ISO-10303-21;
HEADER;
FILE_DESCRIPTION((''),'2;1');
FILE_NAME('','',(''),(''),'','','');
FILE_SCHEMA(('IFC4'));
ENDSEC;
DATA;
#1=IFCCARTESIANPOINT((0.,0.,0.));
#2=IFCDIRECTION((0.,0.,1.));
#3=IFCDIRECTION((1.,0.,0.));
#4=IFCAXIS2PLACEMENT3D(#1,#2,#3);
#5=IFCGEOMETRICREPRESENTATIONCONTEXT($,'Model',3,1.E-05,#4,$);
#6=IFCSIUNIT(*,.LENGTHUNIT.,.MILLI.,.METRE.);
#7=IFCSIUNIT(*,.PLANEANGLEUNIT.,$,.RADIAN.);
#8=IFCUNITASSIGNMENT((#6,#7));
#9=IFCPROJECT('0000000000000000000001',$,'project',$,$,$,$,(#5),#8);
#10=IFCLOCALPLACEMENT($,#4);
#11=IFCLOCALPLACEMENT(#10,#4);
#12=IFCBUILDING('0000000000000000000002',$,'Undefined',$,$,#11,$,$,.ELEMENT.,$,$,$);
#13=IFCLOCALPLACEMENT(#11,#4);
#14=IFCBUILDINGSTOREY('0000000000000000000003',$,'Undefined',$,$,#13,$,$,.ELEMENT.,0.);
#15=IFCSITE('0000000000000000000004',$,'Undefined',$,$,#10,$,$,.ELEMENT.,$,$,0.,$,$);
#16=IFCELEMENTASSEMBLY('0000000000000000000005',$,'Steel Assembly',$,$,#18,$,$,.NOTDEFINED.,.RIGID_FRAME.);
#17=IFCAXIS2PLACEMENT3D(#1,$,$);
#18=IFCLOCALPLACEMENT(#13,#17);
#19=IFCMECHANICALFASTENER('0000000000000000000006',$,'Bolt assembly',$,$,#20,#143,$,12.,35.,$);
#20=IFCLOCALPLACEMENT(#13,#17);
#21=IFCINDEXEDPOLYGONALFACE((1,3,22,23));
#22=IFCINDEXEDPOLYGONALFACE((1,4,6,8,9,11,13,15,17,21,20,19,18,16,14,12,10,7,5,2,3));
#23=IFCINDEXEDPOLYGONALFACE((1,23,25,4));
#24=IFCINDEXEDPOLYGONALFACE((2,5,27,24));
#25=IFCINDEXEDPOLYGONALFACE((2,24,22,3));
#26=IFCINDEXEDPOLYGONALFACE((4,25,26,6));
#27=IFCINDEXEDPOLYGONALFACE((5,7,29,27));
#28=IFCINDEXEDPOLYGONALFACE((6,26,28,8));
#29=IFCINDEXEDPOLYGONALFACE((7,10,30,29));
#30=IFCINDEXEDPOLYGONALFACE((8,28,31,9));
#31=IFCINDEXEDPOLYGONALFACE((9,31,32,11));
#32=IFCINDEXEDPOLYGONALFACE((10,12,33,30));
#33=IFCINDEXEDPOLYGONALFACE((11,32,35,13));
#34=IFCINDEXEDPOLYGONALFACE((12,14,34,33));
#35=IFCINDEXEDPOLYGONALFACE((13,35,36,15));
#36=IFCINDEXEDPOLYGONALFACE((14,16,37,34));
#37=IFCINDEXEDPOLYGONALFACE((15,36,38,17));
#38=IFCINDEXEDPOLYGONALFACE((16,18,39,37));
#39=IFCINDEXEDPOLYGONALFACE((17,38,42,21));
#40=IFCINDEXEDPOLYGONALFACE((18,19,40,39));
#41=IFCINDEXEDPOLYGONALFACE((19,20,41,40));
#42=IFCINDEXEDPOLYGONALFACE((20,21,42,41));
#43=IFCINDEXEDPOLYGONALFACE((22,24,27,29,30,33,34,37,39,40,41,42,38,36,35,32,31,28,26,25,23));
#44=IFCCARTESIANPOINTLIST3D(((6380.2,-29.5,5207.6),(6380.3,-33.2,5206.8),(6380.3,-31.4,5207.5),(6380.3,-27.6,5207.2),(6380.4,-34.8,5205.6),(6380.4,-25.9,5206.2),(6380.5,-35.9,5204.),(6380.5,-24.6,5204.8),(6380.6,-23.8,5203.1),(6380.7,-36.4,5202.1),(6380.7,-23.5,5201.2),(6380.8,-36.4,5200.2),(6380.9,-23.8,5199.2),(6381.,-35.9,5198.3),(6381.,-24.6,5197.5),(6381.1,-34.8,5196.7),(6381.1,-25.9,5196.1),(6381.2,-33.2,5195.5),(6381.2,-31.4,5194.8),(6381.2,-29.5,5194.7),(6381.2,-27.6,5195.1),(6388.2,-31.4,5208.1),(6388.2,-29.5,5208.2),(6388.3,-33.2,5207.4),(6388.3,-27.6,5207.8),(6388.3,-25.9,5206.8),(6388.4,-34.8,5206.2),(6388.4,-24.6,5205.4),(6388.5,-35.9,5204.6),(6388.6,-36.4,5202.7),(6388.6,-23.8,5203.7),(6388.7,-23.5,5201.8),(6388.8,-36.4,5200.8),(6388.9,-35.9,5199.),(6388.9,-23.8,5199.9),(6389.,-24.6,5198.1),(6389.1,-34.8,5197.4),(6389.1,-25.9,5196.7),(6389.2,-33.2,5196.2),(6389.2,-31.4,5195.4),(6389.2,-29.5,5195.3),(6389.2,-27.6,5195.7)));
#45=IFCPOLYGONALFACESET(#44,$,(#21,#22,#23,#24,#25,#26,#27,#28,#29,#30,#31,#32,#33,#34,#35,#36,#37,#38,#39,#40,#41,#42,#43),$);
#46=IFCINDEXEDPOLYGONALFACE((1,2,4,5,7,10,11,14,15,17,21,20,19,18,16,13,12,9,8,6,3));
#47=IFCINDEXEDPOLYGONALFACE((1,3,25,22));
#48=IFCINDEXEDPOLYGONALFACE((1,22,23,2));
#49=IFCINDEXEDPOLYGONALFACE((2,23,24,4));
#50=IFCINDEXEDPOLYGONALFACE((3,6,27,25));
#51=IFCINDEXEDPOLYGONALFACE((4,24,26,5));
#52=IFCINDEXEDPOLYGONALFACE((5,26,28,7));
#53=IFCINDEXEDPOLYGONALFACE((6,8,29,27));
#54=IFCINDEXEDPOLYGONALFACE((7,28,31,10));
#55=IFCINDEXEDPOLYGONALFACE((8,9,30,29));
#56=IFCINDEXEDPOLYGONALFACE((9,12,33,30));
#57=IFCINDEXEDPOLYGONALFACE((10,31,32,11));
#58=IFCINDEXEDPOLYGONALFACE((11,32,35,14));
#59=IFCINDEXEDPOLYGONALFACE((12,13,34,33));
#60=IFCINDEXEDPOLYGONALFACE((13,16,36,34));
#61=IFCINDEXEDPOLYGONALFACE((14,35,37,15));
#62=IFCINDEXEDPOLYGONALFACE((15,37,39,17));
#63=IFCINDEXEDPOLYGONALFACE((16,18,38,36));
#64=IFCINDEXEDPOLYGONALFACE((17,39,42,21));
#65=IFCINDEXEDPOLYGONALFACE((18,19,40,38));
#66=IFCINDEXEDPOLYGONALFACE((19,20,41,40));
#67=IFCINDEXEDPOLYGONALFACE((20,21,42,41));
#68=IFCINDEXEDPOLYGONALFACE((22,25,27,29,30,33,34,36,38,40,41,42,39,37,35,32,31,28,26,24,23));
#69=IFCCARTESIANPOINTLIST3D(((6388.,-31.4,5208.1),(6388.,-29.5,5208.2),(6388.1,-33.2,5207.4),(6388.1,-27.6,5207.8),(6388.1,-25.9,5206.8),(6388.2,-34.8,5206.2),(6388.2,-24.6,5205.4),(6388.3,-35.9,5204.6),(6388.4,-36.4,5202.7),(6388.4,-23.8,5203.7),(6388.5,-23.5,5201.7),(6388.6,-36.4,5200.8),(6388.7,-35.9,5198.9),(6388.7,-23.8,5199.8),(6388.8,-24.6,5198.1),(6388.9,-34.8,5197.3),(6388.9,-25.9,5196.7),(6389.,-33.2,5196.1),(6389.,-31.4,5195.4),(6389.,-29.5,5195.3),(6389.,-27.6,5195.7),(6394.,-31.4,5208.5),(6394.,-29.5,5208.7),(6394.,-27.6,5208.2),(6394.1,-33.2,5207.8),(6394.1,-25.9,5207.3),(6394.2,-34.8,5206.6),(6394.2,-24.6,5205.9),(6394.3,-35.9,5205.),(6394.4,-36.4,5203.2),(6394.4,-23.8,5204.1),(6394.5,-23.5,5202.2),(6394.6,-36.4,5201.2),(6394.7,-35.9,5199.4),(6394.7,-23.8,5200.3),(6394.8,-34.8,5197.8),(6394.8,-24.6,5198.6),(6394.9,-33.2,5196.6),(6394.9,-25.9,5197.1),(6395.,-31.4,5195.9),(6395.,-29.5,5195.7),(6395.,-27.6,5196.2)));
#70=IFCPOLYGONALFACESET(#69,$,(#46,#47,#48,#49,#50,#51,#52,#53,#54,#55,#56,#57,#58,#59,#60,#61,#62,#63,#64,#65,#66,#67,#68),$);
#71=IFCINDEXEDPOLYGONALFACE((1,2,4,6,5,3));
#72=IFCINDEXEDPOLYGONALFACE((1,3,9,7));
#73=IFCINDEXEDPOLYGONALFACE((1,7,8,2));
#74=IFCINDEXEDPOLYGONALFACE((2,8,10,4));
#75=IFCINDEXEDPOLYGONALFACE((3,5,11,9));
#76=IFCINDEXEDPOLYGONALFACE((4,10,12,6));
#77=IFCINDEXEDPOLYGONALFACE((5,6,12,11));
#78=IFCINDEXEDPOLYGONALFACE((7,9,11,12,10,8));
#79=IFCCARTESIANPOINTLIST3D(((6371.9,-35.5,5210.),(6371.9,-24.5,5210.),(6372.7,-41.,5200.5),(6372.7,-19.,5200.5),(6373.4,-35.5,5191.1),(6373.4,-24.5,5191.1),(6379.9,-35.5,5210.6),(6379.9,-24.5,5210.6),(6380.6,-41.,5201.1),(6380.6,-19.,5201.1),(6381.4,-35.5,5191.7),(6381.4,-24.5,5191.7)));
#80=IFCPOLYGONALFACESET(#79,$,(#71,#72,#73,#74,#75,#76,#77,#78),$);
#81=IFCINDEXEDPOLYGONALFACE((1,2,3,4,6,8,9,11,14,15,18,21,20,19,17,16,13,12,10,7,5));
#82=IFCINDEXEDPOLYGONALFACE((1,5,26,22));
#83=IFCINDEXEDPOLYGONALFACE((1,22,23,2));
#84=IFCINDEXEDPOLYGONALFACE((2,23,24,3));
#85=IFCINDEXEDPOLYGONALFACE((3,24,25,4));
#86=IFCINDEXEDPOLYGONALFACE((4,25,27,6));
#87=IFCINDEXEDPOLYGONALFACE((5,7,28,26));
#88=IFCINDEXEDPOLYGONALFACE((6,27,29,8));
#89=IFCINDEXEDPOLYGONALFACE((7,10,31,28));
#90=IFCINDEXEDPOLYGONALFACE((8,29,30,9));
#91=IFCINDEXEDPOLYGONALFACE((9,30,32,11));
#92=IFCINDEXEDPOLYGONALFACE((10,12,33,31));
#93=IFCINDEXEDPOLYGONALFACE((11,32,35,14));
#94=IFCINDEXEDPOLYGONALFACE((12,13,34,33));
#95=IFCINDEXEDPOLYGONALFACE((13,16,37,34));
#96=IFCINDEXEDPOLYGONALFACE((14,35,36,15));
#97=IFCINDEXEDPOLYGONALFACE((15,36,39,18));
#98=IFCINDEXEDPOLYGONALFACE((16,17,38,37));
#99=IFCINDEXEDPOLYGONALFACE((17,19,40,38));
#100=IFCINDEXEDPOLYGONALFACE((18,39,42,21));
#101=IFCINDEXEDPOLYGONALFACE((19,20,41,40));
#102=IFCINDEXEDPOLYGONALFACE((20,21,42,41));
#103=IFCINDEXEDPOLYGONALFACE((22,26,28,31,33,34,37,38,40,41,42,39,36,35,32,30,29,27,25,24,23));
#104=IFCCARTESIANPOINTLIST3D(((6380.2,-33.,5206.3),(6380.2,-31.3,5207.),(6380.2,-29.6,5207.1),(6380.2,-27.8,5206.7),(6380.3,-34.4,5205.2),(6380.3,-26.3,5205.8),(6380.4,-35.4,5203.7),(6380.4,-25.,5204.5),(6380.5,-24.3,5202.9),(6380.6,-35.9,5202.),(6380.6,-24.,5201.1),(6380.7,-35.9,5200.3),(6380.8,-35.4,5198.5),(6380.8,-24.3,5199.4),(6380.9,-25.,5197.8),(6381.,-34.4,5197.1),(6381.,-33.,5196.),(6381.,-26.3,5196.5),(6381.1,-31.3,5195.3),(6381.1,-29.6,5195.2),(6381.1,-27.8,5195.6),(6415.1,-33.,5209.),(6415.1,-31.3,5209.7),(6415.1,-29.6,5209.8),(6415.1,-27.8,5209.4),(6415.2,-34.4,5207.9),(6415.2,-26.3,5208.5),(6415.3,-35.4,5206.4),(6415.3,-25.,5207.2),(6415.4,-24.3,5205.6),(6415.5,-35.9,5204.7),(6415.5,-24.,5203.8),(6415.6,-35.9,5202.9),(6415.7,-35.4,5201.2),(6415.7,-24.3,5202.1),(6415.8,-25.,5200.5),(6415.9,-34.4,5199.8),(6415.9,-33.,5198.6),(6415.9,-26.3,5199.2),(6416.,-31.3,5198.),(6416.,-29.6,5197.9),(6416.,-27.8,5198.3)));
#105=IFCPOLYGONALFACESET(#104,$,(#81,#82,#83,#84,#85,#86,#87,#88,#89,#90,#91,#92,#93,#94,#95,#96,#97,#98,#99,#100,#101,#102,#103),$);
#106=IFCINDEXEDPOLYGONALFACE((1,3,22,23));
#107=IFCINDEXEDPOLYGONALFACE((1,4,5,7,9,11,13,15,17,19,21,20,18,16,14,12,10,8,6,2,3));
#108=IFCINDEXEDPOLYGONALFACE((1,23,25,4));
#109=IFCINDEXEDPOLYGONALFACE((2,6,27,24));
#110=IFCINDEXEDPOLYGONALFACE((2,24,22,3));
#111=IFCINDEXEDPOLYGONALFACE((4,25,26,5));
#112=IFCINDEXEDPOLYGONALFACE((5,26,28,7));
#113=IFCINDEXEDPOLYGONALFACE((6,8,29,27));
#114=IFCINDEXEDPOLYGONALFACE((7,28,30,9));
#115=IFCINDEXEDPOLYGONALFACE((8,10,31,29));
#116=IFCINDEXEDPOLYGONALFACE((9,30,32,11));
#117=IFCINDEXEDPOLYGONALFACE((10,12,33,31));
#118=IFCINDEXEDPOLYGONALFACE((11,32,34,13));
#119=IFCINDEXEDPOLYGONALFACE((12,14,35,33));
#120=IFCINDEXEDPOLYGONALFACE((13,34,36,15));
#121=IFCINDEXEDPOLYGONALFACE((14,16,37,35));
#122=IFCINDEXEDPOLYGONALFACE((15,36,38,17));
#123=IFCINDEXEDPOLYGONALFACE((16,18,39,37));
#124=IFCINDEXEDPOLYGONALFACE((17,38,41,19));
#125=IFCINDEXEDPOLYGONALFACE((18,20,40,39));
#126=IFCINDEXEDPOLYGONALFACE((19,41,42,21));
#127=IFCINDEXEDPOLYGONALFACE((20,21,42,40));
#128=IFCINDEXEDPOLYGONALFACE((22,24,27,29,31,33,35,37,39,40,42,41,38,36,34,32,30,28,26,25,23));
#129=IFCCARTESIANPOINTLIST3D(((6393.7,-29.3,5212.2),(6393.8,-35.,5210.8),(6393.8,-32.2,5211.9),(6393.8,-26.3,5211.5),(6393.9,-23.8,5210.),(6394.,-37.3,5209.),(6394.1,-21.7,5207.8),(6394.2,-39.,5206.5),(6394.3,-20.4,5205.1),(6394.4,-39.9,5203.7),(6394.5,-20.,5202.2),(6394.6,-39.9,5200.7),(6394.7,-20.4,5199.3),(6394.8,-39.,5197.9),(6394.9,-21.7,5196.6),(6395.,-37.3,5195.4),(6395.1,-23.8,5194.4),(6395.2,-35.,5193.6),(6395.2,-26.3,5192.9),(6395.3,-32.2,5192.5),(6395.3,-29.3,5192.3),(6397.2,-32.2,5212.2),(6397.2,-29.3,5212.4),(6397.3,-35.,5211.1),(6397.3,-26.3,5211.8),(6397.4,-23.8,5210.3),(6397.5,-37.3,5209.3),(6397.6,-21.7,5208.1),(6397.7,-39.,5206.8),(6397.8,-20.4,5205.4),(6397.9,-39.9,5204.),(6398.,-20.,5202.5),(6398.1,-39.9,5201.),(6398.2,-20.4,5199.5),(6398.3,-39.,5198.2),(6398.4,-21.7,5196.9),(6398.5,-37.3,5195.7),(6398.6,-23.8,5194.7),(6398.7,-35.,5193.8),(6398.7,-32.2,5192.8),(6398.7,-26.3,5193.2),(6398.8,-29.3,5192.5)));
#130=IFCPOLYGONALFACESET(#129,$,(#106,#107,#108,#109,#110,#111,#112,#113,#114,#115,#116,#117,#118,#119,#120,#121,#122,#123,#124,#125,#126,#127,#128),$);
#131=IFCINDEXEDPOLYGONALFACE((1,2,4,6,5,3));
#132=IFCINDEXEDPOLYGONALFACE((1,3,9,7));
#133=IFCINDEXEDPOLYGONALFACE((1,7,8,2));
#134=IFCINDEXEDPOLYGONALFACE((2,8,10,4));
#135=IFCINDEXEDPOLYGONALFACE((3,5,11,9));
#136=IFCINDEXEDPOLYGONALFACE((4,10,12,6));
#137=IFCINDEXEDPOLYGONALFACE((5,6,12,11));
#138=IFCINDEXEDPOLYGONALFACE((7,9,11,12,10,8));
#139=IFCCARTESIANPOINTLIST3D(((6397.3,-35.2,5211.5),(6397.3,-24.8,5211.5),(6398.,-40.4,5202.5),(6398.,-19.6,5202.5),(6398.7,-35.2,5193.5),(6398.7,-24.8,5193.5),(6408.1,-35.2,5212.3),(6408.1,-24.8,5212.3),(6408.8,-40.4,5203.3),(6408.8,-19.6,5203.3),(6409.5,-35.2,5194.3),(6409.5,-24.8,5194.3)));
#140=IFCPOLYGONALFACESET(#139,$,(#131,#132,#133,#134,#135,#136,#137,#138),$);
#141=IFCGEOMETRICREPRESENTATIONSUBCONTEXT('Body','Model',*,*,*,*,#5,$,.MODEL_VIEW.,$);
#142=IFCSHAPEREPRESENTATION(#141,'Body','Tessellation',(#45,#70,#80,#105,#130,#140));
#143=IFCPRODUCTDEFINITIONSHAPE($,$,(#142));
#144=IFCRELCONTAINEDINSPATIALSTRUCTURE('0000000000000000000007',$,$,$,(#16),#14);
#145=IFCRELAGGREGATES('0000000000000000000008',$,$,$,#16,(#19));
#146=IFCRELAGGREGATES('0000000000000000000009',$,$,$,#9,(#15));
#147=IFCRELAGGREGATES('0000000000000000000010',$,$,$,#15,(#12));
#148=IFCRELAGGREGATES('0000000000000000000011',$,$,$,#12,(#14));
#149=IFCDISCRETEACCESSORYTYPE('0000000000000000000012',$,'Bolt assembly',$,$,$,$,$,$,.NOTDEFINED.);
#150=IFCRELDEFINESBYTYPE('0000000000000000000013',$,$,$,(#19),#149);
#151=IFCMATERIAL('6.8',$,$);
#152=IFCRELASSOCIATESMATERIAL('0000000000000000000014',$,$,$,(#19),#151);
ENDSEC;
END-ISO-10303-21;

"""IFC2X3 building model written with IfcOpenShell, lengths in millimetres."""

from ifc_helpers import new_model, si_unit, frame, origin_with_axes, origin_2d_with_axis, place, context, subcontext, project, spatial, polyline, circle, outline, extrude, source, transform, mapped, material, type_object, element, aggregate, save


model = new_model("IFC2X3")

# Units and contexts
model_context = context("Model", 3, precision=1e-05, world=origin_with_axes())
body_context = subcontext(model_context, "Body", "Model", "MODEL_VIEW")
ifc_project = project(units=[si_unit("LENGTHUNIT", "METRE", prefix="MILLI"), si_unit("PLANEANGLEUNIT", "RADIAN")], contexts=[model_context])

# Site, building, storey
site_placement = place(None, origin_with_axes())
site = spatial("IfcSite", under=ifc_project, at=site_placement, Name="Undefined", CompositionType="ELEMENT", RefElevation=0.0)
building_placement = place(site_placement, origin_with_axes())
building = spatial("IfcBuilding", under=site, at=building_placement, Name="Undefined", CompositionType="ELEMENT")
storey_placement = place(building_placement, origin_with_axes())
storey = spatial("IfcBuildingStorey", under=building, at=storey_placement, Name="Undefined", CompositionType="ELEMENT", Elevation=0.0)

# Element assembly, mechanical fastener
ifc_material_1 = material(Name="6.8")
discrete_accessory_type_1 = type_object("IfcDiscreteAccessoryType", Name="Bolt assembly")
shared_shape_1 = source(origin_with_axes(), body_context, "Body", "SweptSolid", [
    extrude(circle(Radius=6.5, at=origin_2d_with_axis()), frame((0.0, -10.9, 0.0), z_axis=(0.0, 1.0, 0.0), x_axis=(1.0, 0.0, 0.0)), (0.0, 0.0, 1.0), 8.0),
    extrude(circle(Radius=6.5, at=origin_2d_with_axis()), frame((0.0, -3.1, 0.0), z_axis=(0.0, 1.0, 0.0), x_axis=(1.0, 0.0, 0.0)), (0.0, 0.0, 1.0), 6.0),
    extrude(outline(polyline([(11.0, 0.0), (5.5, 9.5), (-5.5, 9.5), (-11.0, 0.0), (-5.5, -9.5), (5.5, -9.5), (11.0, 0.0)])), frame((0.0, -19.0, 0.0), z_axis=(0.0, 1.0, 0.0), x_axis=(1.0, 0.0, 0.0)), (0.0, 0.0, 1.0), 8.0),
    extrude(circle(Radius=6.0, at=origin_2d_with_axis()), frame((0.0, -11.0, 0.0), z_axis=(0.0, 1.0, 0.0), x_axis=(1.0, 0.0, 0.0)), (0.0, 0.0, 1.0), 35.0),
    extrude(circle(Radius=10.0, at=origin_2d_with_axis()), frame((0.0, 3.0, 0.0), z_axis=(0.0, 1.0, 0.0), x_axis=(1.0, 0.0, 0.0)), (0.0, 0.0, 1.0), 3.5),
    extrude(outline(polyline([(10.4, 0.0), (5.2, 9.0), (-5.2, 9.0), (-10.4, 0.0), (-5.2, -9.0), (5.2, -9.0), (10.4, 0.0)])), frame((0.0, 6.5, 0.0), z_axis=(0.0, 1.0, 0.0), x_axis=(1.0, 0.0, 0.0)), (0.0, 0.0, 1.0), 10.8),
])
assembly_1_placement = place(storey_placement, origin_with_axes())
assembly_1 = element("IfcElementAssembly", 1, at=assembly_1_placement, inside=storey, Name="Steel Assembly", AssemblyPlace="NOTDEFINED", PredefinedType="RIGID_FRAME")
mechanical_fastener_1_placement = place(assembly_1_placement, frame((6391.6, -30.0, 5202.0), z_axis=(0.076696, 0.0, -0.997054), x_axis=(0.0, 1.0, 0.0)))
mechanical_fastener_1 = element("IfcMechanicalFastener", 2, at=mechanical_fastener_1_placement, type_object=discrete_accessory_type_1, material=ifc_material_1, Name="Bolt assembly", NominalDiameter=12.0, NominalLength=35.0, context=body_context, shape_type="MappedRepresentation", body=[
    mapped(shared_shape_1, transform((0.0, 0.0, 0.0))),
])
aggregate(assembly_1, [mechanical_fastener_1])

save(model, "model.ifc")
